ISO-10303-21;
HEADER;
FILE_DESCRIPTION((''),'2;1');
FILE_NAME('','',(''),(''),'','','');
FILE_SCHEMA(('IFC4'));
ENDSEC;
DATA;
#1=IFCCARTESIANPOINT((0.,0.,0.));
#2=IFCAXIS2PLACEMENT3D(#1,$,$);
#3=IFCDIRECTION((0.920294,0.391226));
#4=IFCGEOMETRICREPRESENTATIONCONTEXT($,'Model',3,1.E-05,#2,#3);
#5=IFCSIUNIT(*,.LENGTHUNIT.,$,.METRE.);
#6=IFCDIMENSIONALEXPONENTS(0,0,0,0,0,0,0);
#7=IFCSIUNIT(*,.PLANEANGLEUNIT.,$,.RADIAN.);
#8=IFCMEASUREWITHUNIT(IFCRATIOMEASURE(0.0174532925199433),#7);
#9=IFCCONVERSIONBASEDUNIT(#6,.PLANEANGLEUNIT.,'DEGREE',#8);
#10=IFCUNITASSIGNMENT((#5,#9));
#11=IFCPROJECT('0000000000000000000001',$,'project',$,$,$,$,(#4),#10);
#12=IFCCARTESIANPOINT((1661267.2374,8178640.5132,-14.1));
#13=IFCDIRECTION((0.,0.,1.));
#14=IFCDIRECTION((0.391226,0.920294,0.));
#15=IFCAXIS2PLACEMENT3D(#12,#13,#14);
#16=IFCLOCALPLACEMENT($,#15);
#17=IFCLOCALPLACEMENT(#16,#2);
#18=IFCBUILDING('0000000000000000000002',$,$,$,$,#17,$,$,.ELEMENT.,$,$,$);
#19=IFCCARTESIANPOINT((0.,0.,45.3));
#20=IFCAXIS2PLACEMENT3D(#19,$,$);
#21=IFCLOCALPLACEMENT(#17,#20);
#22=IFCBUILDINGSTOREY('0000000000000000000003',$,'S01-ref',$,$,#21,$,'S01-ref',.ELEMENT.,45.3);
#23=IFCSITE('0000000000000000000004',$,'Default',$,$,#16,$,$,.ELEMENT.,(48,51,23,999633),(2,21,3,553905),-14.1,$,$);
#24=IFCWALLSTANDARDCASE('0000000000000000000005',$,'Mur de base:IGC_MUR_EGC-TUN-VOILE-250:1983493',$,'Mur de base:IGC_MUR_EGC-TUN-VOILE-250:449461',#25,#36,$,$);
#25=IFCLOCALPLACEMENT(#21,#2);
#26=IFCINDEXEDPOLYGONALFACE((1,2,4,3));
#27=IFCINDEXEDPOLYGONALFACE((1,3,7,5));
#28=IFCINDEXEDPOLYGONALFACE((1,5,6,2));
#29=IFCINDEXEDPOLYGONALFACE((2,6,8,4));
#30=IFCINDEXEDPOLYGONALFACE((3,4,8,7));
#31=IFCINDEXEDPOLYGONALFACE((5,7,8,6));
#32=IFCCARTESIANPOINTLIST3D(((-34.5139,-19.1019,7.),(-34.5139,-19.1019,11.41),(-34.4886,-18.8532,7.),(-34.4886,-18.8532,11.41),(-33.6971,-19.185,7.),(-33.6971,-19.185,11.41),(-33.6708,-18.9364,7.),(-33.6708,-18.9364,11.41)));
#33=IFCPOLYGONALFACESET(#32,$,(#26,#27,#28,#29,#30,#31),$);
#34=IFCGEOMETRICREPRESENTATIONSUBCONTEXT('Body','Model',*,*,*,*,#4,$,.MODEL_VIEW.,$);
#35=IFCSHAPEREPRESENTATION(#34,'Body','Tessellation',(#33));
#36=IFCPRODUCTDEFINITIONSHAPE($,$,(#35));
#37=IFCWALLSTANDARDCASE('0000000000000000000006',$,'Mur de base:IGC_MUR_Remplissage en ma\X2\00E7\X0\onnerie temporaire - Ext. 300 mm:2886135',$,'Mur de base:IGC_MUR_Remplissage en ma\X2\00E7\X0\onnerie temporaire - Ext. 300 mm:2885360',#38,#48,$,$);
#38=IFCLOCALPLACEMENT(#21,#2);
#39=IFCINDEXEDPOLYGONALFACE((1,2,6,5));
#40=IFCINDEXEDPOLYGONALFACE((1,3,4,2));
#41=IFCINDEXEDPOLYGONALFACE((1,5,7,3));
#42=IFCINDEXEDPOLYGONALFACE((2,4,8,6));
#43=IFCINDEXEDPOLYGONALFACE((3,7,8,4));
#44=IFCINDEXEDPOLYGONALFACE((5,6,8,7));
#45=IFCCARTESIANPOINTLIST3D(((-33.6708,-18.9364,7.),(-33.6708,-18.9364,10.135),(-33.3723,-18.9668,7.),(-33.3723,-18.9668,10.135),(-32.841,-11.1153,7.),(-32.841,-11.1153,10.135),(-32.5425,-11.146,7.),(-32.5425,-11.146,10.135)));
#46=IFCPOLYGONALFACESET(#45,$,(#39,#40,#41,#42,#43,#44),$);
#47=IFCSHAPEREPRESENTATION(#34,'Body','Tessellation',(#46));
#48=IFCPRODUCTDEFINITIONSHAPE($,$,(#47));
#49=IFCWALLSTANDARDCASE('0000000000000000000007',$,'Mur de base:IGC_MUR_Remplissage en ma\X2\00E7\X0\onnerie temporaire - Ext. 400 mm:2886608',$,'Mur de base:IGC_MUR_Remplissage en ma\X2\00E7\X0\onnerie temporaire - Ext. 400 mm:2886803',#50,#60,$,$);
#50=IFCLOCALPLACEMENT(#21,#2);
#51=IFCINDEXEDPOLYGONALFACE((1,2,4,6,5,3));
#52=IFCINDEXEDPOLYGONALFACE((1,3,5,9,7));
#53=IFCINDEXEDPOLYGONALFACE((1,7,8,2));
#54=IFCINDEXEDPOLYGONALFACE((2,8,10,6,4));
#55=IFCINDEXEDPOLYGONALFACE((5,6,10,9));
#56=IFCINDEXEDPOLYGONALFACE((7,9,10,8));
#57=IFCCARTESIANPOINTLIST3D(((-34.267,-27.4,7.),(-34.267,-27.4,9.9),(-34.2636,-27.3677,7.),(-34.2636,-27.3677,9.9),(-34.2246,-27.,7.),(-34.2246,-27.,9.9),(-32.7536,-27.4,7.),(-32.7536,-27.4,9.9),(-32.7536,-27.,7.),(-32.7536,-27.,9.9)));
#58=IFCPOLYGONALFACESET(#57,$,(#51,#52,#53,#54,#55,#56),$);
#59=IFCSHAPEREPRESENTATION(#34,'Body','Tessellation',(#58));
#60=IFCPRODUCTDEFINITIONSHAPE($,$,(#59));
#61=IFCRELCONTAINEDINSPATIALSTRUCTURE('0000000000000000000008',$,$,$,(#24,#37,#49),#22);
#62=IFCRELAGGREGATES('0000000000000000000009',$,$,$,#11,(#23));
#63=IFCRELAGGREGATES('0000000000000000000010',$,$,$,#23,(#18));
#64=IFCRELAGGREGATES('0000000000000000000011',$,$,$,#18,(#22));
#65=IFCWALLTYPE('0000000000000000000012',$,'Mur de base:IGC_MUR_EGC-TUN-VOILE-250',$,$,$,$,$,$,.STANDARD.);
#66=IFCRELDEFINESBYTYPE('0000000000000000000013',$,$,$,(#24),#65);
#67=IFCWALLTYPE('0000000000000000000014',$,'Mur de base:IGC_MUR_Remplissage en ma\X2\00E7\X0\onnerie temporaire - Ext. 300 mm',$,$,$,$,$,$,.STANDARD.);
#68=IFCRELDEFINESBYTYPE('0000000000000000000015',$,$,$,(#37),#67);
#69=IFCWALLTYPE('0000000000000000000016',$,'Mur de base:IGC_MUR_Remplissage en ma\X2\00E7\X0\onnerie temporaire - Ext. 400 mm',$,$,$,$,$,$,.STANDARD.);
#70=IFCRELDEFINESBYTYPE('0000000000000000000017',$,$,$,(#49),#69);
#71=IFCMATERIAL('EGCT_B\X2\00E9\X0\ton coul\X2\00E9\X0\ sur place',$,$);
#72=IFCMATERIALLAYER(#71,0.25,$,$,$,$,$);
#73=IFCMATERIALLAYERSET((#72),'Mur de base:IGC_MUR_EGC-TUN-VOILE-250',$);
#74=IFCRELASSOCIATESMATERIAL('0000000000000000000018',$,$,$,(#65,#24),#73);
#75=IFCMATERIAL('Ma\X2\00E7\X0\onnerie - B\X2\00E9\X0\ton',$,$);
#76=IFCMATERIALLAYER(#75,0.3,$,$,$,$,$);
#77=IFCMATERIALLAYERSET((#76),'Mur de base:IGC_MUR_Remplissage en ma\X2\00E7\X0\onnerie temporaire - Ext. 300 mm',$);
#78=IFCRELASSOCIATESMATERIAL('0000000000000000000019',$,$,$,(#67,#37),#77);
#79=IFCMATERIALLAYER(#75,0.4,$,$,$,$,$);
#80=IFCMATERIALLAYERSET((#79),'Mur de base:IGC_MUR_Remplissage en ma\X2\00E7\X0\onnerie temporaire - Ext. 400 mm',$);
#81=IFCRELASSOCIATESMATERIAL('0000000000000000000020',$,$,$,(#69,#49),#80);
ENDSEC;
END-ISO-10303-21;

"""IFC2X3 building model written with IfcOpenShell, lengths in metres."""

from ifc_helpers import new_model, entity, si_unit, converted_unit, direction, frame, origin, place, context, subcontext, project, spatial, polyline, outline, extrude, material, layer, layer_set, layer_usage, type_object, element, save


model = new_model("IFC2X3")

# Units and contexts
model_context = context("Model", 3, precision=1e-05, world=origin(), true_north=direction((0.920294, 0.391226)))
body_context = subcontext(model_context, "Body", "Model", "MODEL_VIEW")
ifc_project = project(units=[si_unit("LENGTHUNIT", "METRE"), converted_unit("PLANEANGLEUNIT", "DEGREE", entity("IfcRatioMeasure", 0.0174532925199433), si_unit("PLANEANGLEUNIT", "RADIAN"), dimensions=[0, 0, 0, 0, 0, 0, 0])], contexts=[model_context])

# Site, building, storey
site_placement = place(None, frame((1661267.2374, 8178640.5132, -14.1), z_axis=(0.0, 0.0, 1.0), x_axis=(0.391226, 0.920294, 0.0)))
site = spatial("IfcSite", under=ifc_project, at=site_placement, Name="Default", CompositionType="ELEMENT", RefLatitude=(48, 51, 23, 999633), RefLongitude=(2, 21, 3, 553905), RefElevation=-14.1)
building_placement = place(site_placement, origin())
building = spatial("IfcBuilding", under=site, at=building_placement, CompositionType="ELEMENT")
storey_placement = place(building_placement, frame((0.0, 0.0, 45.3)))
storey = spatial("IfcBuildingStorey", under=building, at=storey_placement, Name="S01-ref", LongName="S01-ref", CompositionType="ELEMENT", Elevation=45.3)

# Walls
ifc_material_1 = material(Name="EGCT_Béton coulé sur place")
ifc_layer_1 = layer(ifc_material_1, 0.25)
ifc_layer_set_1 = layer_set([ifc_layer_1], Name="Mur de base:IGC_MUR_EGC-TUN-VOILE-250")
ifc_layer_usage_1 = layer_usage(ifc_layer_set_1, "AXIS2", "NEGATIVE", 0.125)
wall_type_1 = type_object("IfcWallType", Name="Mur de base:IGC_MUR_EGC-TUN-VOILE-250", PredefinedType="STANDARD", material=ifc_layer_set_1)
wall_1_placement = place(storey_placement, frame((-33.6834, -19.0608, 7.0), z_axis=(0.0, 0.0, 1.0), x_axis=(-0.994864, 0.101222, 0.0)))
element("IfcWallStandardCase", 1, at=wall_1_placement, inside=storey, type_object=wall_type_1, material=ifc_layer_usage_1, Name="Mur de base:IGC_MUR_EGC-TUN-VOILE-250:1983493", ObjectType="Mur de base:IGC_MUR_EGC-TUN-VOILE-250:449461", context=body_context, shape_type="SweptSolid", body=[
    extrude(outline(polyline([(0.8221, -0.125), (0.8221, 0.125), (0.0011, 0.125), (0.0, -0.125), (0.8221, -0.125)])), origin(), (0.0, 0.0, 1.0), 4.41),
])
ifc_material_2 = material(Name="Maçonnerie - Béton")
ifc_layer_2 = layer(ifc_material_2, 0.3)
ifc_layer_set_2 = layer_set([ifc_layer_2], Name="Mur de base:IGC_MUR_Remplissage en maçonnerie temporaire - Ext. 300 mm")
ifc_layer_usage_2 = layer_usage(ifc_layer_set_2, "AXIS2", "NEGATIVE", 0.15)
wall_type_2 = type_object("IfcWallType", Name="Mur de base:IGC_MUR_Remplissage en maçonnerie temporaire - Ext. 300 mm", PredefinedType="STANDARD", material=ifc_layer_set_2)
wall_2_placement = place(storey_placement, frame((-33.5216, -18.9522, 7.0), z_axis=(0.0, 0.0, 1.0), x_axis=(0.105506, 0.994419, 0.0)))
element("IfcWallStandardCase", 2, at=wall_2_placement, inside=storey, type_object=wall_type_2, material=ifc_layer_usage_2, Name="Mur de base:IGC_MUR_Remplissage en maçonnerie temporaire - Ext. 300 mm:2886135", ObjectType="Mur de base:IGC_MUR_Remplissage en maçonnerie temporaire - Ext. 300 mm:2885360", context=body_context, shape_type="SweptSolid", body=[
    extrude(outline(polyline([(7.8659, -0.15), (7.865, 0.15), (0.0, 0.15), (0.0013, -0.15), (7.8659, -0.15)])), origin(), (0.0, 0.0, 1.0), 3.135),
])
ifc_layer_3 = layer(ifc_material_2, 0.4)
ifc_layer_set_3 = layer_set([ifc_layer_3], Name="Mur de base:IGC_MUR_Remplissage en maçonnerie temporaire - Ext. 400 mm")
ifc_layer_usage_3 = layer_usage(ifc_layer_set_3, "AXIS2", "NEGATIVE", 0.2)
wall_type_3 = type_object("IfcWallType", Name="Mur de base:IGC_MUR_Remplissage en maçonnerie temporaire - Ext. 400 mm", PredefinedType="STANDARD", material=ifc_layer_set_3)
wall_3_placement = place(storey_placement, frame((-32.7536, -27.2, 7.0), z_axis=(0.0, 0.0, 1.0), x_axis=(-1.0, 0.0, 0.0)))
element("IfcWallStandardCase", 3, at=wall_3_placement, inside=storey, type_object=wall_type_3, material=ifc_layer_usage_3, Name="Mur de base:IGC_MUR_Remplissage en maçonnerie temporaire - Ext. 400 mm:2886608", ObjectType="Mur de base:IGC_MUR_Remplissage en maçonnerie temporaire - Ext. 400 mm:2886803", context=body_context, shape_type="SweptSolid", body=[
    extrude(outline(polyline([(1.471, -0.2), (1.51, 0.1677), (1.5134, 0.2), (0.0, 0.2), (0.0, -0.2), (1.471, -0.2)])), origin(), (0.0, 0.0, 1.0), 2.9),
])

save(model, "model.ifc")
